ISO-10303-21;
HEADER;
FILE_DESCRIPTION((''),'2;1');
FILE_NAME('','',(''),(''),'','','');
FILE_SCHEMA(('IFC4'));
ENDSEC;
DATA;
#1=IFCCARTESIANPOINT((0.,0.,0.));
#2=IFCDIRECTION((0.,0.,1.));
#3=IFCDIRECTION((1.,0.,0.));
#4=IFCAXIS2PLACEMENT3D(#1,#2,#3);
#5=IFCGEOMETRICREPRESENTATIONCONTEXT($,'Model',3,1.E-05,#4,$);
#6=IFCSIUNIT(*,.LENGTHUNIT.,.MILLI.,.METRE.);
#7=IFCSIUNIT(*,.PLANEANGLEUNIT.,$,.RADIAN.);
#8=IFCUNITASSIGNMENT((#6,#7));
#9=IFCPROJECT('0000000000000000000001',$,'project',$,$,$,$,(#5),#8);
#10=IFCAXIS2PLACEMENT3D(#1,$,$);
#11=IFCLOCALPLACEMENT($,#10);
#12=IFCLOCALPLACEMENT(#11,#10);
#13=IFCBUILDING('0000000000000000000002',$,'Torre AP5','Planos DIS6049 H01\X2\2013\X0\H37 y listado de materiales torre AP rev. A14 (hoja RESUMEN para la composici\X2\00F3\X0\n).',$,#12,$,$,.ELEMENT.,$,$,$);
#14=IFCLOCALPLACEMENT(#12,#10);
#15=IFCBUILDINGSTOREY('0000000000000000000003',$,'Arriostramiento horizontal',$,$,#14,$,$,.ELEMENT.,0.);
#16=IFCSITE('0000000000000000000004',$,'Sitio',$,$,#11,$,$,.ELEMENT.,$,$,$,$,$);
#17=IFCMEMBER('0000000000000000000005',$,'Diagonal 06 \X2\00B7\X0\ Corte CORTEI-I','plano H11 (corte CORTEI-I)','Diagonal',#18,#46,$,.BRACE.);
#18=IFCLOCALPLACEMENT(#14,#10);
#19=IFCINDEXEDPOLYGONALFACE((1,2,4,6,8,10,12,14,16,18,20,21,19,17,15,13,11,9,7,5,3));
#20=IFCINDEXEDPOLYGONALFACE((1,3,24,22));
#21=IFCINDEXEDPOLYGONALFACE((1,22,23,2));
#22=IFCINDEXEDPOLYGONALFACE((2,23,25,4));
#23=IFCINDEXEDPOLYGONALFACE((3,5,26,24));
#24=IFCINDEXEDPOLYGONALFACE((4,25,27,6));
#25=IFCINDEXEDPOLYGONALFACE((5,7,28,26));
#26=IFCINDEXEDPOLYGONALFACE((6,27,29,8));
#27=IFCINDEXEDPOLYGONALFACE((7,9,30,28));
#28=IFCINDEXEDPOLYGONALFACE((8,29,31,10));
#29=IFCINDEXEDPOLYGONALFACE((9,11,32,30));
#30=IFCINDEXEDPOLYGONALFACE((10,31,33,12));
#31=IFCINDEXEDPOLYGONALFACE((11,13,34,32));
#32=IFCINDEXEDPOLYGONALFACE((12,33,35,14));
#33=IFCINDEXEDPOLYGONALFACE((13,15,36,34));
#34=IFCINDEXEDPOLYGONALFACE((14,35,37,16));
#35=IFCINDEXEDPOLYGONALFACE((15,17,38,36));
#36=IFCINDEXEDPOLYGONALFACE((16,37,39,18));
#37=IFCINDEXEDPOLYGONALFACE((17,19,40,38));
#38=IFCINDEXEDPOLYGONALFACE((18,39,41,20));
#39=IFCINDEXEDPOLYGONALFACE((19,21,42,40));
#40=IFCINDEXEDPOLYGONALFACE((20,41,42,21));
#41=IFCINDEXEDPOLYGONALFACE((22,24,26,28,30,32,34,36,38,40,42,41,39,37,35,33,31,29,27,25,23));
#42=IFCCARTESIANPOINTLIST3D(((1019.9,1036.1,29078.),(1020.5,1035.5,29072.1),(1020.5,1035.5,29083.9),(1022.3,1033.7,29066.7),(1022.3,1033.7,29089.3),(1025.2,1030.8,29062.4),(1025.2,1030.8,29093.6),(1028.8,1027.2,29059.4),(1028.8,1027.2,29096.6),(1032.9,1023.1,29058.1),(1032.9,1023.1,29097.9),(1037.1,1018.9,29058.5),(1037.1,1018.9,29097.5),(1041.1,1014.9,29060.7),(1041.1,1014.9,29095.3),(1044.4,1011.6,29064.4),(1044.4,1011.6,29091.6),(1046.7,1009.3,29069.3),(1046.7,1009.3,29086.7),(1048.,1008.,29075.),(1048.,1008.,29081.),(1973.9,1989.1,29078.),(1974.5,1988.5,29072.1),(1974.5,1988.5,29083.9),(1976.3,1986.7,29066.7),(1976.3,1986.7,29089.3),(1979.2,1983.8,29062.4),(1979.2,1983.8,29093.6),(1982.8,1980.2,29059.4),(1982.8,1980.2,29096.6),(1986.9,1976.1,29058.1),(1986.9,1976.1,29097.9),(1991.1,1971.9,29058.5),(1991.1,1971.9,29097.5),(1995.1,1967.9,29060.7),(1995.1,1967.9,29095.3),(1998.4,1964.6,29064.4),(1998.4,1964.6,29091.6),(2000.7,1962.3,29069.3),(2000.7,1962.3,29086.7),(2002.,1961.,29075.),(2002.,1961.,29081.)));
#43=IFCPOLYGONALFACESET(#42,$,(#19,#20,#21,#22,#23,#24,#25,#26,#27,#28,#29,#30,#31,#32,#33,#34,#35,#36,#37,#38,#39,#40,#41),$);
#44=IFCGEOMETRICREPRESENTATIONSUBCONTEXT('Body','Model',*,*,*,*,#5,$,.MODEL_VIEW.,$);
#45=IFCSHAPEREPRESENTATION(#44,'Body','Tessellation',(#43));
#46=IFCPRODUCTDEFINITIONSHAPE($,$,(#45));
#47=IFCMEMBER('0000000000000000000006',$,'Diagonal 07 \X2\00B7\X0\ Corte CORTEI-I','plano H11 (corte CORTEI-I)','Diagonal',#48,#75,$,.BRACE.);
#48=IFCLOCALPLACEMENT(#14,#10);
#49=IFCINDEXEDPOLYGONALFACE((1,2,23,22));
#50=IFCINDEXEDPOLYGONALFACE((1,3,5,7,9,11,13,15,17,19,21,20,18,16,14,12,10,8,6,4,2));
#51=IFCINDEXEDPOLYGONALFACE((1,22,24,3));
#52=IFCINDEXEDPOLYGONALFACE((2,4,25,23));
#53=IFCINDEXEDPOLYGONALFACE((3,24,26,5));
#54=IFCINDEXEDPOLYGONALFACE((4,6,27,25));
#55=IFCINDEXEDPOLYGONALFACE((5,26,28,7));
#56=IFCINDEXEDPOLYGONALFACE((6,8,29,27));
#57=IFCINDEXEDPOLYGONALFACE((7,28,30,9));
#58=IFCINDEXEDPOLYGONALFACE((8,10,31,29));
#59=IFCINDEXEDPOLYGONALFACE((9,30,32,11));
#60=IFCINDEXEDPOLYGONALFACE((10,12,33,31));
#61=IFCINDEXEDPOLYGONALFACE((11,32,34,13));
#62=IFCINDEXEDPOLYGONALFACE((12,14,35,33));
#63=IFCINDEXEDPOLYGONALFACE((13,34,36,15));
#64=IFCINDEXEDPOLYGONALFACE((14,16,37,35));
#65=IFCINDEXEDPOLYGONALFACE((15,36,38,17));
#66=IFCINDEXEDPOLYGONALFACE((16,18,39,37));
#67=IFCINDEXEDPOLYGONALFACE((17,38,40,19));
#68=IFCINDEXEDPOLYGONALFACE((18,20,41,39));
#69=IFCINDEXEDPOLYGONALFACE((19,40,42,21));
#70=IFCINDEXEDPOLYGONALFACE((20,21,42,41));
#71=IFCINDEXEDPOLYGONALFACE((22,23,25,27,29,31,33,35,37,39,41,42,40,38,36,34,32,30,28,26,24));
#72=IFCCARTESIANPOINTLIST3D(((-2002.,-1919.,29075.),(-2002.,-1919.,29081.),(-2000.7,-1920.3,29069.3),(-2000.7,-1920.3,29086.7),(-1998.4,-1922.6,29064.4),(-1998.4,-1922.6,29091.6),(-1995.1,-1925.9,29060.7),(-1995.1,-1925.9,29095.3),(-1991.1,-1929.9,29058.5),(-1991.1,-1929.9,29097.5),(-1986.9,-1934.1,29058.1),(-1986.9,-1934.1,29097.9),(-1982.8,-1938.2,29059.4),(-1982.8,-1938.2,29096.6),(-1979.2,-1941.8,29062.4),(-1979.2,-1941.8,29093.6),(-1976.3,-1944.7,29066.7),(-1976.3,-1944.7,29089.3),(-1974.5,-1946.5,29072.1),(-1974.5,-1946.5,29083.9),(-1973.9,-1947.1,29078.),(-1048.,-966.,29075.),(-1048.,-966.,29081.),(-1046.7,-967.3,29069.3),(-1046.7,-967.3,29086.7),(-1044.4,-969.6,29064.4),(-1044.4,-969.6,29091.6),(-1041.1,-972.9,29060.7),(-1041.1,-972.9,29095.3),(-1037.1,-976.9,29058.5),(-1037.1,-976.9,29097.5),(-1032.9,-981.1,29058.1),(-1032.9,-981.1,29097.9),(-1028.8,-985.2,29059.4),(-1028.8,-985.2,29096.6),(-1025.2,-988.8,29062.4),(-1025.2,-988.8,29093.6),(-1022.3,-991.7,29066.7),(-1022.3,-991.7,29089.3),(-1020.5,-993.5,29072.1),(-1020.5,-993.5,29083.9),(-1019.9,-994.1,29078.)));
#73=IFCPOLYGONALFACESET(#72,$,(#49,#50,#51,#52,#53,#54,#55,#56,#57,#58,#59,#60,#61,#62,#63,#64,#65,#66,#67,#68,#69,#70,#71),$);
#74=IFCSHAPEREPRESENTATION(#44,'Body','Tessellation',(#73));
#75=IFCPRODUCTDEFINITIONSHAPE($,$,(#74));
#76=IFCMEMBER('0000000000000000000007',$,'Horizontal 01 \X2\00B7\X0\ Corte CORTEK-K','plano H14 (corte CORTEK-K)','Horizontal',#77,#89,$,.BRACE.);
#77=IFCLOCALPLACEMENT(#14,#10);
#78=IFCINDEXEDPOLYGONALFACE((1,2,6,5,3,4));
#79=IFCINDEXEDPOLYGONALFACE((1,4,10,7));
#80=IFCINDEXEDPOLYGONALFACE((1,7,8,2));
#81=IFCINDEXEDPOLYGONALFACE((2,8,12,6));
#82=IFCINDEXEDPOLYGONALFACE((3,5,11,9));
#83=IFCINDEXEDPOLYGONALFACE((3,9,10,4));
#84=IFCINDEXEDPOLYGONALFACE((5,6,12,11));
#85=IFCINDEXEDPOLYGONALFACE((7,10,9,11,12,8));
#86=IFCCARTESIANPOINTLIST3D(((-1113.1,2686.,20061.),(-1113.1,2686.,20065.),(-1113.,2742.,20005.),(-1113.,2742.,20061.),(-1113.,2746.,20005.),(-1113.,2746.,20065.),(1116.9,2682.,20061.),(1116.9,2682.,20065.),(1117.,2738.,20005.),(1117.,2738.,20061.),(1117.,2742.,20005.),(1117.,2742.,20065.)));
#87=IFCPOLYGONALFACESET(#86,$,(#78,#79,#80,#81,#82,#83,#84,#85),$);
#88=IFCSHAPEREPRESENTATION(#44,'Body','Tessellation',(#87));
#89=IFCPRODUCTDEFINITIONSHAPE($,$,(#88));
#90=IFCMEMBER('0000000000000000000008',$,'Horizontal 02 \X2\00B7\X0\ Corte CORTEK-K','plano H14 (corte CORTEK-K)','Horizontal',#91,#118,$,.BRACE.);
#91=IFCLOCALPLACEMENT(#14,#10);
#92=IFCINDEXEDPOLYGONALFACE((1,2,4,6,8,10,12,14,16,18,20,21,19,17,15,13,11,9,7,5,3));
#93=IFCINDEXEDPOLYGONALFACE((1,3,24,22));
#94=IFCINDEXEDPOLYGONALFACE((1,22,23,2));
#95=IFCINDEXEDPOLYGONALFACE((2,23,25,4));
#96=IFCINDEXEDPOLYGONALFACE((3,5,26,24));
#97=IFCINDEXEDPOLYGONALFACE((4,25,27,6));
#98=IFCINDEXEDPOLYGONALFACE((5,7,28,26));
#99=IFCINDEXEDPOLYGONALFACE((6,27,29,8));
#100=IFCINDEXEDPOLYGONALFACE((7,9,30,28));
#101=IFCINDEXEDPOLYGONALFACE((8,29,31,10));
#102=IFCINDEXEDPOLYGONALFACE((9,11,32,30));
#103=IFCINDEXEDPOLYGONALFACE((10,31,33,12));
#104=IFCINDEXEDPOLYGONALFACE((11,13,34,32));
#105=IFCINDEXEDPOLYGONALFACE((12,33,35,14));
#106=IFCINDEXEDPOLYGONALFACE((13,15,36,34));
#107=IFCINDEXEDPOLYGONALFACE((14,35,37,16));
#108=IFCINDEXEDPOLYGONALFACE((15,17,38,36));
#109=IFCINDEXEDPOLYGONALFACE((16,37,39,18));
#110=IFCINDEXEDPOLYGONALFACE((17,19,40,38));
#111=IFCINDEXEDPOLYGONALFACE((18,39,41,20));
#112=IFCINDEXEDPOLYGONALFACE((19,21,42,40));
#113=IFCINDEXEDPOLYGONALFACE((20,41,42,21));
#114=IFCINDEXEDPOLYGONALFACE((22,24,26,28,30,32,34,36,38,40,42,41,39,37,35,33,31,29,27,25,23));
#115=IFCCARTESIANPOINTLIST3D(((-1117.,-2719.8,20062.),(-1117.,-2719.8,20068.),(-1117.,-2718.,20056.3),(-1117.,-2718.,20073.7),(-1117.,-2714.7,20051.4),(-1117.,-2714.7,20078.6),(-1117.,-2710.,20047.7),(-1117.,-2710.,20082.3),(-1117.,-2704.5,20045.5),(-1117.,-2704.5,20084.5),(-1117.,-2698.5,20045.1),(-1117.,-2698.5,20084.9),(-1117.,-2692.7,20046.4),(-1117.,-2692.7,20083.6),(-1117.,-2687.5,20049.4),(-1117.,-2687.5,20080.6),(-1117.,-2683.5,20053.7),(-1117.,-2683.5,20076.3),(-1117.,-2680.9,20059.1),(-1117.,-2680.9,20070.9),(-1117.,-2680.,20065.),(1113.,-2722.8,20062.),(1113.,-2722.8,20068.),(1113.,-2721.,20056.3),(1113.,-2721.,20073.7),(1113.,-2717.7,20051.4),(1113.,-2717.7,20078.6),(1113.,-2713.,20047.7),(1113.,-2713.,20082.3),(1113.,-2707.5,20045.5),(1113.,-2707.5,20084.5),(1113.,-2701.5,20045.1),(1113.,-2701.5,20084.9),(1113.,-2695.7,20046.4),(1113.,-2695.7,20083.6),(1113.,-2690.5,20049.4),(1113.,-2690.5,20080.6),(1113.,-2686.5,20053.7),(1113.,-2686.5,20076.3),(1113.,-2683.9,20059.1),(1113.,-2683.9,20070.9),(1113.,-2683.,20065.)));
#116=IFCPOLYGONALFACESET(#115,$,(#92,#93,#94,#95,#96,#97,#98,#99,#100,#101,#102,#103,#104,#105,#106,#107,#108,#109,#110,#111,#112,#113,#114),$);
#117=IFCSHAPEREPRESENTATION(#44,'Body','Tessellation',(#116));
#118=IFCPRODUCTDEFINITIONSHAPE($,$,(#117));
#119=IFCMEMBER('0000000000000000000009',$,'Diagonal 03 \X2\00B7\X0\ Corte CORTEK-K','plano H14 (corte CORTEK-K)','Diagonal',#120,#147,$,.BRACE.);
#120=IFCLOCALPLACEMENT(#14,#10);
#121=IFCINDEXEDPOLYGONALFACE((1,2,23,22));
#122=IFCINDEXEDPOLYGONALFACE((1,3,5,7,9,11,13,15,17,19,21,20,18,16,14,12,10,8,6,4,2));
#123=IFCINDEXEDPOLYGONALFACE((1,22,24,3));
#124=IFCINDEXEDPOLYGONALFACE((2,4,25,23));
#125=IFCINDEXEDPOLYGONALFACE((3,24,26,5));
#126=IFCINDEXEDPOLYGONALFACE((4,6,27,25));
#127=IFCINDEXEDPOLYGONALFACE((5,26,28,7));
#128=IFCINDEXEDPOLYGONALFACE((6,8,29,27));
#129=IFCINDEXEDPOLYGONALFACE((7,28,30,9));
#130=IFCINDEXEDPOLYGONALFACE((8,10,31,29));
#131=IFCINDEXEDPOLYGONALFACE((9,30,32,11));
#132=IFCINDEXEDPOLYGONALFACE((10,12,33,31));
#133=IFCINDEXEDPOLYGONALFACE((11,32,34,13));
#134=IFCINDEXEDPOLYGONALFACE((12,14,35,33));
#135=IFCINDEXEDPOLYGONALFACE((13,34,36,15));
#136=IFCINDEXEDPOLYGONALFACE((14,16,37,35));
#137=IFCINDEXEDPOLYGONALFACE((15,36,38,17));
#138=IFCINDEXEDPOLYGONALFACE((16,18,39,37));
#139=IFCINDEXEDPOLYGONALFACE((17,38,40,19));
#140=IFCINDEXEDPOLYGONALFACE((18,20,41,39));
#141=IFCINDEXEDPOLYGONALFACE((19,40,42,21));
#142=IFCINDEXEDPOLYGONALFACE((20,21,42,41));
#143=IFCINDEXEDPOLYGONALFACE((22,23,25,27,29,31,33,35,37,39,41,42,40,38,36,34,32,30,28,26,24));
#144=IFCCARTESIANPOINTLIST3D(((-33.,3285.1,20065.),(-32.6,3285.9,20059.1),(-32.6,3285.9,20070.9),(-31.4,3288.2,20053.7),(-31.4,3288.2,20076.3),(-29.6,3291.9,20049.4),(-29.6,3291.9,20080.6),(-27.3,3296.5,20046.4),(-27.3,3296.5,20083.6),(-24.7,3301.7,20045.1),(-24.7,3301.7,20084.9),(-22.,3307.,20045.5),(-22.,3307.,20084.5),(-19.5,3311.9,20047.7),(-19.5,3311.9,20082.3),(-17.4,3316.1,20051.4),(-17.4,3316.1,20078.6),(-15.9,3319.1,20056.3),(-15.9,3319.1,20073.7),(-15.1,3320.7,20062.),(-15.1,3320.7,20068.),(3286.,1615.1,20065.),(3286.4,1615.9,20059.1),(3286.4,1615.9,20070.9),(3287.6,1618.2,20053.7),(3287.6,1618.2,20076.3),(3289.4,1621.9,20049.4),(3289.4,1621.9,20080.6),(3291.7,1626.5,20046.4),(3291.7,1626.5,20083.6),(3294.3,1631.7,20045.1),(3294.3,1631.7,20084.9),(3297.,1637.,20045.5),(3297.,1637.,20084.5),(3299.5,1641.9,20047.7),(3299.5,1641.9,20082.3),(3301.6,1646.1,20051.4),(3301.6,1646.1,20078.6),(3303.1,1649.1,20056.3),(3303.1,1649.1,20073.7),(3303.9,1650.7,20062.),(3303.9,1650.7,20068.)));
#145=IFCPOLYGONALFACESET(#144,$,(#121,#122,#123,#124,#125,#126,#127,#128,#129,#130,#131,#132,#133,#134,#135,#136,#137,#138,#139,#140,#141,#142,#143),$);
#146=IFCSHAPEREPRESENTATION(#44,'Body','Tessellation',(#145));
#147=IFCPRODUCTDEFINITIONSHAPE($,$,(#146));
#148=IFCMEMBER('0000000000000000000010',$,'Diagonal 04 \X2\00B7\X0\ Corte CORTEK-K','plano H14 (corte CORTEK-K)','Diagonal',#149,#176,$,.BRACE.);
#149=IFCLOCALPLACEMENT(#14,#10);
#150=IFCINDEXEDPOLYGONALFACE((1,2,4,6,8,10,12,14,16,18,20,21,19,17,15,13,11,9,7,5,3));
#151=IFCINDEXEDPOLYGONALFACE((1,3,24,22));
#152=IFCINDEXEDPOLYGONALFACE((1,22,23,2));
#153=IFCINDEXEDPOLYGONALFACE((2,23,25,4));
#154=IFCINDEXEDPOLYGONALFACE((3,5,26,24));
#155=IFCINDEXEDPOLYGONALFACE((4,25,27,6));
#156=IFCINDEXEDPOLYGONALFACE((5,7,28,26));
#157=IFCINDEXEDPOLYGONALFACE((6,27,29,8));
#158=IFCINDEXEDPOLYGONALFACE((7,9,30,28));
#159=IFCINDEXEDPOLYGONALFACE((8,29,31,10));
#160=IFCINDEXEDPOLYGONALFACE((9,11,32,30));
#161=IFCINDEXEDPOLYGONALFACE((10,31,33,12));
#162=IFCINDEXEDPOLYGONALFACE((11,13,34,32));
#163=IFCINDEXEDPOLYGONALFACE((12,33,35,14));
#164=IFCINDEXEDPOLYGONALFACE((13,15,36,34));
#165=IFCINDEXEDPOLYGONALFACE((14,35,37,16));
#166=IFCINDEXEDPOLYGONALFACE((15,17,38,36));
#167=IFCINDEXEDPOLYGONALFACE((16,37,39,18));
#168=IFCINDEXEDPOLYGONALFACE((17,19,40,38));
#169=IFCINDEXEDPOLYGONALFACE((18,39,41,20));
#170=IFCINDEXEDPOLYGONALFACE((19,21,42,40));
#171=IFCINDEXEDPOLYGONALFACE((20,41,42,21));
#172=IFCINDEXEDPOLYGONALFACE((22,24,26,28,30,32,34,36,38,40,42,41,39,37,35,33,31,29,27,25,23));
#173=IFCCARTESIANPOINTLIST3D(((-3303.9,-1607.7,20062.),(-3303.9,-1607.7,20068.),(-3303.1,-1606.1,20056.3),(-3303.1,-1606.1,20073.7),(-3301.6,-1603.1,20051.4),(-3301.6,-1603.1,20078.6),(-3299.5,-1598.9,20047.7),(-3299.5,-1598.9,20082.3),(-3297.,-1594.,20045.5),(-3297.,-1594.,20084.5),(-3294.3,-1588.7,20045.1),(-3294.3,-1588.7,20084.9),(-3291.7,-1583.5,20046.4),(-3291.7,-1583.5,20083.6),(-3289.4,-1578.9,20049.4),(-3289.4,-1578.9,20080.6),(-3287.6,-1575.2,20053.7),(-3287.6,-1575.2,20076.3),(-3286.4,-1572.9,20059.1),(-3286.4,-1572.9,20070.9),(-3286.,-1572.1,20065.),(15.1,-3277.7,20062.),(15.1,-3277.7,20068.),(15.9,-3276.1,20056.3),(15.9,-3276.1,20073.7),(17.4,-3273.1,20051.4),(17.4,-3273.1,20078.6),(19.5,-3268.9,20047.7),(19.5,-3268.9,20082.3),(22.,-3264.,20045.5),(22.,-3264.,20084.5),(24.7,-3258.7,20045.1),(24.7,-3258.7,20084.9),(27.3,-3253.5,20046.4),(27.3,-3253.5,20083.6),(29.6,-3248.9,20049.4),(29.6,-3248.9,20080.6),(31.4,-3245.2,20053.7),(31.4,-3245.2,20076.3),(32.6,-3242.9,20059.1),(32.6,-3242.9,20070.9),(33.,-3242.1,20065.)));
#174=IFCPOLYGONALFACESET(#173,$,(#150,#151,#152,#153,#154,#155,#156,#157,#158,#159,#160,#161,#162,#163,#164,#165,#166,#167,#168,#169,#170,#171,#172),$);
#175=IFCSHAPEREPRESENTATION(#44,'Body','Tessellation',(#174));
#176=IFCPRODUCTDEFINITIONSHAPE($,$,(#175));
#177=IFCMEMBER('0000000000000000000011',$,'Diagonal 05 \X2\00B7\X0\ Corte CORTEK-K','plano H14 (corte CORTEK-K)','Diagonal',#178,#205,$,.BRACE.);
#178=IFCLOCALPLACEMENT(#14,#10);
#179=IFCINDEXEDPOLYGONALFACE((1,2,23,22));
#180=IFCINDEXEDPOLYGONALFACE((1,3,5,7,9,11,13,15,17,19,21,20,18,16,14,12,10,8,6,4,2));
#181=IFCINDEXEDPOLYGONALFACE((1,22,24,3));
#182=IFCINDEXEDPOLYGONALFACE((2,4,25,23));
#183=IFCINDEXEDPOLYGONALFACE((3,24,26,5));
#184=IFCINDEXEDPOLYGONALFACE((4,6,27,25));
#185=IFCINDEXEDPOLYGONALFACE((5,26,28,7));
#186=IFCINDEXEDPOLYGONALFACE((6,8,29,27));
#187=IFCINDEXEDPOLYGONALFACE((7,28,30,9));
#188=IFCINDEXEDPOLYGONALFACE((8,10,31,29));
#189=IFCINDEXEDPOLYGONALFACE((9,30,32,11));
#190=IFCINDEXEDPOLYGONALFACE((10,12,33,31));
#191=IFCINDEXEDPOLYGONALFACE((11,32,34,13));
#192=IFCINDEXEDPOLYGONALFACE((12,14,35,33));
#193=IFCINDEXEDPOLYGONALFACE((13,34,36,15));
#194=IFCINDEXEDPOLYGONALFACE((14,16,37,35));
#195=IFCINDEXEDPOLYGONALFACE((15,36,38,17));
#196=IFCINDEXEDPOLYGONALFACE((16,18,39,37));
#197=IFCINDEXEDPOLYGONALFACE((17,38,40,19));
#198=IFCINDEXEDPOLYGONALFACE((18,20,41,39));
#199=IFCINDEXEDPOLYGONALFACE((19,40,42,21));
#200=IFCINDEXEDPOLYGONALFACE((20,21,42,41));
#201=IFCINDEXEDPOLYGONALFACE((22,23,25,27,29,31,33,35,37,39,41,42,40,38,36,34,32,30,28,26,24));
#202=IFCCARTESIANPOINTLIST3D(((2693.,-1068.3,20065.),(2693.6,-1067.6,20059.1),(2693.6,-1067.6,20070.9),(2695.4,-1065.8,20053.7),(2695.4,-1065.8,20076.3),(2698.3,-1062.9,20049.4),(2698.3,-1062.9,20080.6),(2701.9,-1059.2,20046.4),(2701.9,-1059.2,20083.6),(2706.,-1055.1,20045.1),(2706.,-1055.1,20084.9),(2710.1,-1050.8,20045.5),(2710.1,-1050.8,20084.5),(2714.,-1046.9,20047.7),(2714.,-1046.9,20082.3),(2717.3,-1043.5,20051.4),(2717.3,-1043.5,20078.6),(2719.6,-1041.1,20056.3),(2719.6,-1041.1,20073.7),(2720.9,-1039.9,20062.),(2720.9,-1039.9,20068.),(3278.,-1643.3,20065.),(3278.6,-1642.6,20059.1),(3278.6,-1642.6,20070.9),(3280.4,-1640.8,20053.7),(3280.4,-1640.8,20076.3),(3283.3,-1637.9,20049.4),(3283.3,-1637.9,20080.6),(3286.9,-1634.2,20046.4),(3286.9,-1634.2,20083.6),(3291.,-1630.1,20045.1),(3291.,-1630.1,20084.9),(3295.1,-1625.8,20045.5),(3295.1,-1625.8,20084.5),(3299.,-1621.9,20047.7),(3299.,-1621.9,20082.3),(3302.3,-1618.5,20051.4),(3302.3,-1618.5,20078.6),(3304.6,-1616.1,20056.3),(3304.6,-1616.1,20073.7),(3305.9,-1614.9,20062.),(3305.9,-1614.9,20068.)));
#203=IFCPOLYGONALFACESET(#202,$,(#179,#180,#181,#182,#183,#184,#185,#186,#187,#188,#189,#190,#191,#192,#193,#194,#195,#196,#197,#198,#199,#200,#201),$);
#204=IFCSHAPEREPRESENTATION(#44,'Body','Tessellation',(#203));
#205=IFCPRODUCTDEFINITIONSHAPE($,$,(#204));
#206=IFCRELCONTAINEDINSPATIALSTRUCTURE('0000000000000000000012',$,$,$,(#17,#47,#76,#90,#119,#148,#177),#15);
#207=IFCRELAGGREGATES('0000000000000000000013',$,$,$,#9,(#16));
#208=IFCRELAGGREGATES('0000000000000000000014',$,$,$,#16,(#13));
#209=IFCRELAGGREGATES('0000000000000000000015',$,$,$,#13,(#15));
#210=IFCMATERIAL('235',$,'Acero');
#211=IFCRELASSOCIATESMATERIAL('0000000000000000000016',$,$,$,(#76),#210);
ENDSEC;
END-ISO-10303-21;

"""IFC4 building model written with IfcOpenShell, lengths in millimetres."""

from ifc_helpers import new_model, si_unit, frame, frame_2d, origin, origin_with_axes, place, context, subcontext, project, spatial, circle, l_section, extrude, material, element, save


model = new_model("IFC4")

# Units and contexts
model_context = context("Model", 3, precision=1e-05, world=origin_with_axes())
body_context = subcontext(model_context, "Body", "Model", "MODEL_VIEW")
ifc_project = project(units=[si_unit("LENGTHUNIT", "METRE", prefix="MILLI"), si_unit("PLANEANGLEUNIT", "RADIAN")], contexts=[model_context])

# Site, building, storey
site_placement = place(None, origin())
site = spatial("IfcSite", under=ifc_project, at=site_placement, Name="Sitio", CompositionType="ELEMENT")
building_placement = place(site_placement, origin())
building = spatial("IfcBuilding", under=site, at=building_placement, Name="Torre AP5", Description="Planos DIS6049 H01–H37 y listado de materiales torre AP rev. A14 (hoja RESUMEN para la composición).", CompositionType="ELEMENT")
storey_placement = place(building_placement, origin())
storey = spatial("IfcBuildingStorey", under=building, at=storey_placement, Name="Arriostramiento horizontal", CompositionType="ELEMENT", Elevation=0.0)

# Members
ifc_material = material(Name="235", Category="Acero")
for number, where, z_axis, x_axis, name in (
    (1, (1988.0, 1975.0, 29078.0), (-0.707477, -0.706736, 0.0), (-0.706736, 0.707477, 0.0), "Diagonal 06 · Corte CORTEI-I"),
    (2, (-1034.0, -980.0, 29078.0), (-0.707477, -0.706736, 0.0), (0.706736, -0.707477, 0.0), "Diagonal 07 · Corte CORTEI-I"),
):
    element("IfcMember", number, at=place(storey_placement, frame(where, z_axis=z_axis, x_axis=x_axis)), inside=storey, Name=name, Description="plano H11 (corte CORTEI-I)", ObjectType="Diagonal", PredefinedType="BRACE", context=body_context, shape_type="SweptSolid", body=[
        extrude(circle(Radius=20.0), None, (0.0, 0.0, 1.0), 1348.5),
    ])
member_1_placement = place(storey_placement, frame((-1113.0, 2746.0, 20065.0), z_axis=(0.999998, -0.001794, 0.0), x_axis=(-0.001794, -0.999998, 0.0)))
element("IfcMember", 3, at=member_1_placement, inside=storey, material=ifc_material, Name="Horizontal 01 · Corte CORTEK-K", Description="plano H14 (corte CORTEK-K)", ObjectType="Horizontal", PredefinedType="BRACE", context=body_context, shape_type="SweptSolid", body=[
    extrude(l_section(Depth=60.0, Width=60.0, Thickness=4.0, at=frame_2d((30.0, 30.0))), None, (0.0, 0.0, 1.0), 2230.0),
])
member_2_placement = place(storey_placement, frame((-1117.0, -2700.0, 20065.0), z_axis=(0.999999, -0.001345, 0.0), x_axis=(0.001345, 0.999999, 0.0)))
element("IfcMember", 4, at=member_2_placement, inside=storey, Name="Horizontal 02 · Corte CORTEK-K", Description="plano H14 (corte CORTEK-K)", ObjectType="Horizontal", PredefinedType="BRACE", context=body_context, shape_type="SweptSolid", body=[
    extrude(circle(Radius=20.0), None, (0.0, 0.0, 1.0), 2230.0),
])
for number, where, z_axis, x_axis, name in (
    (5, (-24.0, 3303.0, 20065.0), (0.893294, -0.449473, 0.0), (-0.449473, -0.893294, 0.0), "Diagonal 03 · Corte CORTEK-K"),
    (6, (-3295.0, -1590.0, 20065.0), (0.893294, -0.449473, 0.0), (0.449473, 0.893294, 0.0), "Diagonal 04 · Corte CORTEK-K"),
):
    element("IfcMember", number, at=place(storey_placement, frame(where, z_axis=z_axis, x_axis=x_axis)), inside=storey, Name=name, Description="plano H14 (corte CORTEK-K)", ObjectType="Diagonal", PredefinedType="BRACE", context=body_context, shape_type="SweptSolid", body=[
        extrude(circle(Radius=20.0), None, (0.0, 0.0, 1.0), 3715.5),
    ])
member_3_placement = place(storey_placement, frame((2707.0, -1054.0, 20065.0), z_axis=(0.713176, -0.700985, 0.0), x_axis=(-0.700985, -0.713176, 0.0)))
element("IfcMember", 7, at=member_3_placement, inside=storey, Name="Diagonal 05 · Corte CORTEK-K", Description="plano H14 (corte CORTEK-K)", ObjectType="Diagonal", PredefinedType="BRACE", context=body_context, shape_type="SweptSolid", body=[
    extrude(circle(Radius=20.0), None, (0.0, 0.0, 1.0), 820.3),
])

save(model, "model.ifc")
